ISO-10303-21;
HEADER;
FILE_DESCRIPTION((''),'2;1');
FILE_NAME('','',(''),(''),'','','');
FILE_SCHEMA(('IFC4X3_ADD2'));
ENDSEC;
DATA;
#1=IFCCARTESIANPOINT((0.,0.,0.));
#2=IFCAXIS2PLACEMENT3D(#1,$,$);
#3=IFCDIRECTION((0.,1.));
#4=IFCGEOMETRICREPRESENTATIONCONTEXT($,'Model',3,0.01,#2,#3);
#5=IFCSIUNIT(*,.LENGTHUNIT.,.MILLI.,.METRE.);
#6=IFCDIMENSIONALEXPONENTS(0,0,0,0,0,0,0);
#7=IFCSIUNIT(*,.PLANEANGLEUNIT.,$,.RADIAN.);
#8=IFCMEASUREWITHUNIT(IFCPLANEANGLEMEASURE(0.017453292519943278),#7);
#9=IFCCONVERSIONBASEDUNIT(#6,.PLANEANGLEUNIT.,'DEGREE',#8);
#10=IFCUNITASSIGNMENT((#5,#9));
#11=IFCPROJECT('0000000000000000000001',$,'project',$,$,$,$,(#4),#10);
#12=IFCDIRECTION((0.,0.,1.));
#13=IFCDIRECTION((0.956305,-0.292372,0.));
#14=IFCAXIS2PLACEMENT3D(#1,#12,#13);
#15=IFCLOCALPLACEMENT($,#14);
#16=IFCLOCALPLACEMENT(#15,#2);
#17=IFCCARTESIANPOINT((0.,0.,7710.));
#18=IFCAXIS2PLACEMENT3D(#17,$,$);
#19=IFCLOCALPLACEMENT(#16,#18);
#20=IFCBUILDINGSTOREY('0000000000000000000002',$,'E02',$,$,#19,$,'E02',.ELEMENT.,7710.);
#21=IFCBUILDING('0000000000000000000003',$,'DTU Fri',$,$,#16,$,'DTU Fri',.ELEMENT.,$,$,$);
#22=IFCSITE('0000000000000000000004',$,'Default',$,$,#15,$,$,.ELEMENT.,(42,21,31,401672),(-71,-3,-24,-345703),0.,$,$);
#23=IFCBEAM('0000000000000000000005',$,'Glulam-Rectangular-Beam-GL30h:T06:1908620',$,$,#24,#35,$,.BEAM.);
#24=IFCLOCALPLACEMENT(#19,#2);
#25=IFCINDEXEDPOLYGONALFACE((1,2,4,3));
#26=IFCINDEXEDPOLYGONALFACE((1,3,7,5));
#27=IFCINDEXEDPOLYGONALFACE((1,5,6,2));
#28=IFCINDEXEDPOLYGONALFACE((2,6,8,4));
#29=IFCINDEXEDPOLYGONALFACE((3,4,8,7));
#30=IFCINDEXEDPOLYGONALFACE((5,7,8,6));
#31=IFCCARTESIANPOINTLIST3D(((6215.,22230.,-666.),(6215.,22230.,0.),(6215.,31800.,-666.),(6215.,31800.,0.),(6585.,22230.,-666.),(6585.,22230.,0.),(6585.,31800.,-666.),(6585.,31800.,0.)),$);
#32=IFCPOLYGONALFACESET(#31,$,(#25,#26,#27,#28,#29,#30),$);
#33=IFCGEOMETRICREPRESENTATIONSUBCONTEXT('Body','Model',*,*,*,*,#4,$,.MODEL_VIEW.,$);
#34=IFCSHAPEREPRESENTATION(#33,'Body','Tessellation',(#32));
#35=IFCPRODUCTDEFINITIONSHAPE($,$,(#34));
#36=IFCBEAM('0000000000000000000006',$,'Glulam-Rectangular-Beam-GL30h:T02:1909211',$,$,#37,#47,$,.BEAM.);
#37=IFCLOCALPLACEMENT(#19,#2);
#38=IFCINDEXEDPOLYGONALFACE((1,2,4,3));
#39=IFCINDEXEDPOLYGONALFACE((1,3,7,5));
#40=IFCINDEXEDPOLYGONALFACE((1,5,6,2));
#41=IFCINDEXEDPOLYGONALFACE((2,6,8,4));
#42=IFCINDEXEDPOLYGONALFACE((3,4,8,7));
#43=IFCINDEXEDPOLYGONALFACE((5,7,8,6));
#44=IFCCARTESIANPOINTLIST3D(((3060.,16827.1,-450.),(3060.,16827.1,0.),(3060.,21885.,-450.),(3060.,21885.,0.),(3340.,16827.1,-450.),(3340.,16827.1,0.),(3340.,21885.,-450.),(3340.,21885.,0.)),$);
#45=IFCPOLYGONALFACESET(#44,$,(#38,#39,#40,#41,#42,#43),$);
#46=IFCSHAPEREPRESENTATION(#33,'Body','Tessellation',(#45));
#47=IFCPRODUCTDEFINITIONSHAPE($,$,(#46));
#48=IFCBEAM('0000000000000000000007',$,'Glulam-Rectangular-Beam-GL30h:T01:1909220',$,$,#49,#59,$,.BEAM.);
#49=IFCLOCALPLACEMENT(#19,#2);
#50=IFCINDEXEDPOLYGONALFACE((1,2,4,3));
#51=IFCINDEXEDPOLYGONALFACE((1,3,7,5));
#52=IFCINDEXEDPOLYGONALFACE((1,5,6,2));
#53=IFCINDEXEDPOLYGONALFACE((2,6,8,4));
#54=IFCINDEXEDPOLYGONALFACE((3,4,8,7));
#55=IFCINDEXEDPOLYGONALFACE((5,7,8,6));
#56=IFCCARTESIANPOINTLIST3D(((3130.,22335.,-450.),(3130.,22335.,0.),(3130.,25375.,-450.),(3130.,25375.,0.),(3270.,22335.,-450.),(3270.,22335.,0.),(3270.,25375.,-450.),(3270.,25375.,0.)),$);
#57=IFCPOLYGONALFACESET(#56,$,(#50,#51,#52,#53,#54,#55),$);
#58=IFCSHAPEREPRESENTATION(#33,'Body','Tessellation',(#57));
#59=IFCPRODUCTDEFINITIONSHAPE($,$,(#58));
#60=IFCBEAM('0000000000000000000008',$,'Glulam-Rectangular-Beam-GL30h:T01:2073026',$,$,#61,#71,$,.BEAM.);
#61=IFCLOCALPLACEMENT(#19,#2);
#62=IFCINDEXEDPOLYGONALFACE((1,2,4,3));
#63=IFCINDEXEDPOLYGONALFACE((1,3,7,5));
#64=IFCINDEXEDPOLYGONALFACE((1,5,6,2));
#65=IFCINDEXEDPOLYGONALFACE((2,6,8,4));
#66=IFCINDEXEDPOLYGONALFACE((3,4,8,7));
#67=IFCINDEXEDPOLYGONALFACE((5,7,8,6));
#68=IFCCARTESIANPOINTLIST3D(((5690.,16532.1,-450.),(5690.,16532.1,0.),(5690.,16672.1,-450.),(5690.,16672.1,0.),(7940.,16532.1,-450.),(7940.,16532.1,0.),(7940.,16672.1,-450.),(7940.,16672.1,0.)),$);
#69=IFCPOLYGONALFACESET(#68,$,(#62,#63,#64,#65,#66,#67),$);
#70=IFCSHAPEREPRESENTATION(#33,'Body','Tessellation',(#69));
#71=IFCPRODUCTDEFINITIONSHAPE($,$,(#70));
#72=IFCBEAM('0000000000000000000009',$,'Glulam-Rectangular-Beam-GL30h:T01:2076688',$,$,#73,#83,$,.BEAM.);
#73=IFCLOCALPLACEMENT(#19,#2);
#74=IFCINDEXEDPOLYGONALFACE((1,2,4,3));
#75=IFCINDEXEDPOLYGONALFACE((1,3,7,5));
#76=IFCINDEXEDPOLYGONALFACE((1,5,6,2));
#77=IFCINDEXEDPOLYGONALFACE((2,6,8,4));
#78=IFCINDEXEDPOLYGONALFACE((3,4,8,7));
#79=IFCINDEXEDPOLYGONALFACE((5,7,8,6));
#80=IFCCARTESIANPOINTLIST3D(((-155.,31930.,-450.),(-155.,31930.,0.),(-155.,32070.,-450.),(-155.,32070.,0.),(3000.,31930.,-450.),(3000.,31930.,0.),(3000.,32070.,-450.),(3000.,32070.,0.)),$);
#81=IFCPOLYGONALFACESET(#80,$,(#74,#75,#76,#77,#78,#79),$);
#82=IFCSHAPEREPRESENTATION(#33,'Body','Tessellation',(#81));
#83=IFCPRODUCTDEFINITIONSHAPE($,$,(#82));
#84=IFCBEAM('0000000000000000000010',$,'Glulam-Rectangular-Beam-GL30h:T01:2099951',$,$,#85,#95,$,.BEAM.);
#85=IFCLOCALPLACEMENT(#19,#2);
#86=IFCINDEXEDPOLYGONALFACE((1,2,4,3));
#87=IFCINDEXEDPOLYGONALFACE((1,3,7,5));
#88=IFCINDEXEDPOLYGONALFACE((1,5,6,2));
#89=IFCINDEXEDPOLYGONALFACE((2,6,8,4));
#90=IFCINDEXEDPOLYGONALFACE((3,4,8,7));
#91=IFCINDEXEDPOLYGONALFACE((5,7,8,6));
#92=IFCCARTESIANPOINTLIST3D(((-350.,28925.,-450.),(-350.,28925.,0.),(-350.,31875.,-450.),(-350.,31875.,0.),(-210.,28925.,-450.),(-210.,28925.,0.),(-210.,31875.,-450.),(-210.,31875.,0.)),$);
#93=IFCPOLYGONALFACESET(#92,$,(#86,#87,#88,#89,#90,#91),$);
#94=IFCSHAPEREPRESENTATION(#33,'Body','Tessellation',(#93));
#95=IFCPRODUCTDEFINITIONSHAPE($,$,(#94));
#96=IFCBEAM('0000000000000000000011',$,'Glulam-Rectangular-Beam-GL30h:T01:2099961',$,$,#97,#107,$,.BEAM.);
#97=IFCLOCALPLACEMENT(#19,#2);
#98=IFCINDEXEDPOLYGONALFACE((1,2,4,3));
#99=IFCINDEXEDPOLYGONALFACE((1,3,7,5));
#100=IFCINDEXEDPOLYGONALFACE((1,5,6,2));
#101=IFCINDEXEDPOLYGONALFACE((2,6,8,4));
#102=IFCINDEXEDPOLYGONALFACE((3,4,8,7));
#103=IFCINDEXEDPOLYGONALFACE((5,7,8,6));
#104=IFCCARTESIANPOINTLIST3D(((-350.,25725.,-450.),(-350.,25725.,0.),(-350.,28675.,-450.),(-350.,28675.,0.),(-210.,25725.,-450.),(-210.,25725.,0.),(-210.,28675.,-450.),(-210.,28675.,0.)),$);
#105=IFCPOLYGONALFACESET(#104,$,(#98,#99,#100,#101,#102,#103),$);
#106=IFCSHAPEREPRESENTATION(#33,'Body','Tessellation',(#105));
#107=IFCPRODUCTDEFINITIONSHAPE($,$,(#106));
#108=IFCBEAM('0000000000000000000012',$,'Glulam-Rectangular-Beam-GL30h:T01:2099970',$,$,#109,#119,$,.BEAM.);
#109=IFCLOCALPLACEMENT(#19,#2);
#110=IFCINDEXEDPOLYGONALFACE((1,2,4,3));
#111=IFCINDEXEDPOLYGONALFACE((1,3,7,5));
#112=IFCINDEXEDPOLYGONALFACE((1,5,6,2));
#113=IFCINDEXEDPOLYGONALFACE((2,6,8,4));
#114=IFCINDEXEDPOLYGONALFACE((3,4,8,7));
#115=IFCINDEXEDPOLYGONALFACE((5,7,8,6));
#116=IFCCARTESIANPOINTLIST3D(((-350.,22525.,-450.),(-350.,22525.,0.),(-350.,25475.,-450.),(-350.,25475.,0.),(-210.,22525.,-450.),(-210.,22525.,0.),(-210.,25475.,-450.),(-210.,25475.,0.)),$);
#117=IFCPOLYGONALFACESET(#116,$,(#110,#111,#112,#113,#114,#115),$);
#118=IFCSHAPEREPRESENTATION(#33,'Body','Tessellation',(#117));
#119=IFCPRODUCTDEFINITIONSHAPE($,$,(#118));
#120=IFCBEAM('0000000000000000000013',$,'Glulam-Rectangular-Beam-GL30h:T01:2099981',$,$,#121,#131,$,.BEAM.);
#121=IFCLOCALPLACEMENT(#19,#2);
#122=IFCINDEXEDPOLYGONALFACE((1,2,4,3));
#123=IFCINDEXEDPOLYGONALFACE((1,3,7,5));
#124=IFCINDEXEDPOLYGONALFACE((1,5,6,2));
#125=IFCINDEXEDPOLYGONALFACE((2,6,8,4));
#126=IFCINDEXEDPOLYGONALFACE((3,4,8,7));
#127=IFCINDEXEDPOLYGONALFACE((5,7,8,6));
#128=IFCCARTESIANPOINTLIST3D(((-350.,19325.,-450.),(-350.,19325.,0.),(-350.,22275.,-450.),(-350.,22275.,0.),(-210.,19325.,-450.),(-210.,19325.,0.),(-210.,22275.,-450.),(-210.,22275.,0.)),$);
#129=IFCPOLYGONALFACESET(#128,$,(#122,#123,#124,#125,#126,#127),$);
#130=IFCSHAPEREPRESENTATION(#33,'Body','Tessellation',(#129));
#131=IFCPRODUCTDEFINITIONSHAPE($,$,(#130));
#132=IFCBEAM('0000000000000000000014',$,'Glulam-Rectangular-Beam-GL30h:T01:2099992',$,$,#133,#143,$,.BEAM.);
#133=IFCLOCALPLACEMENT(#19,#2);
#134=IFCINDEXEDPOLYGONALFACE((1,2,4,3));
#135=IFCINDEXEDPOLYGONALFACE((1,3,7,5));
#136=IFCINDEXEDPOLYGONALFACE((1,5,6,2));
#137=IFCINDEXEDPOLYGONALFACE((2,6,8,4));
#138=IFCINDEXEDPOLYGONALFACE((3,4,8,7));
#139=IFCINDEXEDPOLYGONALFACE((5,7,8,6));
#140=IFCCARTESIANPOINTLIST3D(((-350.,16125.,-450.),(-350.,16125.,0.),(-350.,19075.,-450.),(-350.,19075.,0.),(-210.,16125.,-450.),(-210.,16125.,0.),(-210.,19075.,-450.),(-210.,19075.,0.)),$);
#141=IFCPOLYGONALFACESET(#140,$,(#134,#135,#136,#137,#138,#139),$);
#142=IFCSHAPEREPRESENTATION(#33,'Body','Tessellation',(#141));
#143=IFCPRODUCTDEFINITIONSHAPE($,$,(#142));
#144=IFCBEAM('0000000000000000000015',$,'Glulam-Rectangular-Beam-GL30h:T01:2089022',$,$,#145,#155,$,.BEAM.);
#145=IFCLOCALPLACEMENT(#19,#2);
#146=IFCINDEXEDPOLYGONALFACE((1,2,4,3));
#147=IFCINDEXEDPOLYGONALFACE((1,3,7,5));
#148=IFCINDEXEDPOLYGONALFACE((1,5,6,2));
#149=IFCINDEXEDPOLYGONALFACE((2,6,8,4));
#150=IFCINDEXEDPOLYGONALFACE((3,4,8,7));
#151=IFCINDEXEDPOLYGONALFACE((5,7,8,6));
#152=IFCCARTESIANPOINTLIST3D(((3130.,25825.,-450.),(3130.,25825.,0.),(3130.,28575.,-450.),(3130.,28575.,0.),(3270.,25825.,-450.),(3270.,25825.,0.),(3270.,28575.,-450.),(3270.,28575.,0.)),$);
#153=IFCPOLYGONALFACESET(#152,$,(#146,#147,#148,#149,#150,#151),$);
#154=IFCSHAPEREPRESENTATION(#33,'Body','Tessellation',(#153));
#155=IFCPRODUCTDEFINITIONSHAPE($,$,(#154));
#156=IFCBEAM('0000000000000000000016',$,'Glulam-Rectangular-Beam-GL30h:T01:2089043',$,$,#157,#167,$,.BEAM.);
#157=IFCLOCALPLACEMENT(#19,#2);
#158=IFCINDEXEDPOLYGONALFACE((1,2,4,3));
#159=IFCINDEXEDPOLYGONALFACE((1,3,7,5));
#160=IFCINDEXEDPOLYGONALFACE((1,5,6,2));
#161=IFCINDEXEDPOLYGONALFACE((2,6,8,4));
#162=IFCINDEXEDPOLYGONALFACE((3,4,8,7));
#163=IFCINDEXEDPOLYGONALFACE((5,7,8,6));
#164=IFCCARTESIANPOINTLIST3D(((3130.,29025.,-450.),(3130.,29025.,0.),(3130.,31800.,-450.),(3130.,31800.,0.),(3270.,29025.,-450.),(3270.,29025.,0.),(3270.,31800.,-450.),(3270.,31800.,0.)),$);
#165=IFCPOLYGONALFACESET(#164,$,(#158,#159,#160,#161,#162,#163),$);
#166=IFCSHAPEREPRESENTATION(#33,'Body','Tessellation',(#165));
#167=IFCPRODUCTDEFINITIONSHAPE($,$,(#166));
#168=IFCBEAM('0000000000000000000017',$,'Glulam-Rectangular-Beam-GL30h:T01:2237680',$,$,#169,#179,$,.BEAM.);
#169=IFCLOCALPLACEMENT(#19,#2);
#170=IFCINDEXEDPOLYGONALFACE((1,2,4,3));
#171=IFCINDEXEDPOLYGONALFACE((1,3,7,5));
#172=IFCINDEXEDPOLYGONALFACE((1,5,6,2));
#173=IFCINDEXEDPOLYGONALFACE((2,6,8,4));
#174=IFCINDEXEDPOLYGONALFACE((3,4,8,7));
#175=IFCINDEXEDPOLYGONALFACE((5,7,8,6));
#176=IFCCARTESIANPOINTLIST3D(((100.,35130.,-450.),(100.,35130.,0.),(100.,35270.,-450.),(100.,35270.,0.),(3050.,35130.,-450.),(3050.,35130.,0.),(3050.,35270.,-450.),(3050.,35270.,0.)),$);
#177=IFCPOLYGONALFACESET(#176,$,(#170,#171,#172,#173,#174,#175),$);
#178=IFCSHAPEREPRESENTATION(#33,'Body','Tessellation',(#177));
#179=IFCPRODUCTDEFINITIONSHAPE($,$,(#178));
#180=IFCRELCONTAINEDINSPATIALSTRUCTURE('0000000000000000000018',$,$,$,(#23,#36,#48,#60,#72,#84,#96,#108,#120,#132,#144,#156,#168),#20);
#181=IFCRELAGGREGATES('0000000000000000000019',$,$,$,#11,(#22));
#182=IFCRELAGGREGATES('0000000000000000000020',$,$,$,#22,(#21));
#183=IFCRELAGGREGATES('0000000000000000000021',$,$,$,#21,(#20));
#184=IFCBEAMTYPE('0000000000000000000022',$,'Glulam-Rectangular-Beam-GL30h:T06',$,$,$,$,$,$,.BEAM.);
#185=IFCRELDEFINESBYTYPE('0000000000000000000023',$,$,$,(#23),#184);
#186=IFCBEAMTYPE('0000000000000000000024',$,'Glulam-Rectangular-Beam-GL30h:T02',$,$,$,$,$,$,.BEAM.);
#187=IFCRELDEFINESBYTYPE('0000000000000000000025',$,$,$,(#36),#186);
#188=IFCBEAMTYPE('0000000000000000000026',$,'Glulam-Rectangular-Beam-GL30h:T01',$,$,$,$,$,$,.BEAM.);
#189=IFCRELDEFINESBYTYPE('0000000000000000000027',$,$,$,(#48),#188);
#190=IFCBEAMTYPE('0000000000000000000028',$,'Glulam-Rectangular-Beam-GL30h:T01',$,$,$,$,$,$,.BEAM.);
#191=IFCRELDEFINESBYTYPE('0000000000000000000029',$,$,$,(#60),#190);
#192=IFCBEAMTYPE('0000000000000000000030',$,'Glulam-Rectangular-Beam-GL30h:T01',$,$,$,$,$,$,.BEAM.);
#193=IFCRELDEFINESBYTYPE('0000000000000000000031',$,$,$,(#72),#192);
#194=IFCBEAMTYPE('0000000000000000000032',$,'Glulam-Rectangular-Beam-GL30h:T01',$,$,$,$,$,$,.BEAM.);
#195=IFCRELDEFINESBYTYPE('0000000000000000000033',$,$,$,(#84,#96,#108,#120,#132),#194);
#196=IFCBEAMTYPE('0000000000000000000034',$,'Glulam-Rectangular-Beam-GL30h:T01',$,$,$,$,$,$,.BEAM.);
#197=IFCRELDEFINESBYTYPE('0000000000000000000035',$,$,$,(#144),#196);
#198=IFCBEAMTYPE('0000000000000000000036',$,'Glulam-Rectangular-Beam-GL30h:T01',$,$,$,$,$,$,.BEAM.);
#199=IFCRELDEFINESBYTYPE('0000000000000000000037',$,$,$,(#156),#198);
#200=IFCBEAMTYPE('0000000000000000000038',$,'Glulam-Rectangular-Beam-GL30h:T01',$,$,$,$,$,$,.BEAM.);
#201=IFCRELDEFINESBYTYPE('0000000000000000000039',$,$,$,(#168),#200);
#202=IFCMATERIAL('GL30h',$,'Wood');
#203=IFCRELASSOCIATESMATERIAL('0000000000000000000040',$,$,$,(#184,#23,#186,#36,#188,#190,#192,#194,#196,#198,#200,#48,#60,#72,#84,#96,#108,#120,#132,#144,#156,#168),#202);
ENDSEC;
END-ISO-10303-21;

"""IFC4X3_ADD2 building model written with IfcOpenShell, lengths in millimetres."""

from ifc_helpers import new_model, entity, si_unit, converted_unit, direction, frame, origin, origin_2d_with_axis, place, context, subcontext, project, spatial, rectangle, extrude, source, transform, mapped, material, material_profile, profile_set, profile_usage, type_object, type_shapes, element, save


model = new_model("IFC4X3_ADD2")

# Units and contexts
model_context = context("Model", 3, precision=0.01, world=origin(), true_north=direction((0.0, 1.0)))
body_context = subcontext(model_context, "Body", "Model", "MODEL_VIEW")
ifc_project = project(units=[si_unit("LENGTHUNIT", "METRE", prefix="MILLI"), converted_unit("PLANEANGLEUNIT", "DEGREE", entity("IfcPlaneAngleMeasure", 0.017453292519943278), si_unit("PLANEANGLEUNIT", "RADIAN"), dimensions=[0, 0, 0, 0, 0, 0, 0])], contexts=[model_context])

# Site, building, storey
site_placement = place(None, frame((0.0, 0.0, 0.0), z_axis=(0.0, 0.0, 1.0), x_axis=(0.956305, -0.292372, 0.0)))
site = spatial("IfcSite", under=ifc_project, at=site_placement, Name="Default", CompositionType="ELEMENT", RefLatitude=(42, 21, 31, 401672), RefLongitude=(-71, -3, -24, -345703), RefElevation=0.0)
building_placement = place(site_placement, origin())
building = spatial("IfcBuilding", under=site, at=building_placement, Name="DTU Fri", LongName="DTU Fri", CompositionType="ELEMENT")
storey_placement = place(building_placement, frame((0.0, 0.0, 7710.0)))
storey = spatial("IfcBuildingStorey", under=building, at=storey_placement, Name="E02", LongName="E02", CompositionType="ELEMENT", Elevation=7710.0)

# Shared definitions
ifc_material_1 = material(Name="GL30h", Category="Wood")

# Beams
ifc_material_profile_1 = material_profile(ifc_material_1, rectangle(XDim=450.0, YDim=280.0, at=origin_2d_with_axis()), Name="T02")
ifc_profile_set_1 = profile_set([ifc_material_profile_1], Name="T02")
ifc_profile_usage_1 = profile_usage(ifc_profile_set_1, cardinal=8)
ifc_material_profile_2 = material_profile(ifc_material_1, rectangle(XDim=666.0, YDim=370.0, at=origin_2d_with_axis()), Name="T06")
ifc_profile_set_2 = profile_set([ifc_material_profile_2], Name="T06")
ifc_profile_usage_2 = profile_usage(ifc_profile_set_2, cardinal=8)
beam_type_1 = type_object("IfcBeamType", Name="Glulam-Rectangular-Beam-GL30h:T06", PredefinedType="BEAM", material=ifc_profile_set_2)
shared_shape_1 = source(origin(), body_context, "Body", "SweptSolid", [
    extrude(rectangle(XDim=666.0, YDim=370.0, at=origin_2d_with_axis()), frame((-4825.0, 0.0, 0.0), z_axis=(1.0, 0.0, 0.0), x_axis=(0.0, 0.0, -1.0)), (0.0, 0.0, 1.0), 9570.0),
])
type_shapes(beam_type_1, [shared_shape_1])
beam_1_placement = place(storey_placement, frame((6400.0, 27055.0, -333.0), z_axis=(0.0, 0.0, 1.0), x_axis=(0.0, 1.0, 0.0)))
element("IfcBeam", 1, at=beam_1_placement, inside=storey, type_object=beam_type_1, material=ifc_profile_usage_2, Name="Glulam-Rectangular-Beam-GL30h:T06:1908620", PredefinedType="BEAM", context=body_context, shape_type="MappedRepresentation", body=[
    mapped(shared_shape_1, transform((0.0, 0.0, 0.0), scale=1.0)),
])
beam_type_2 = type_object("IfcBeamType", Name="Glulam-Rectangular-Beam-GL30h:T02", PredefinedType="BEAM", material=ifc_profile_set_1)
shared_shape_2 = source(origin(), body_context, "Body", "SweptSolid", [
    extrude(rectangle(XDim=450.0, YDim=280.0, at=origin_2d_with_axis()), frame((-2529.0, 0.0, 0.0), z_axis=(1.0, 0.0, 0.0), x_axis=(0.0, 0.0, -1.0)), (0.0, 0.0, 1.0), 5057.9),
])
type_shapes(beam_type_2, [shared_shape_2])
beam_2_placement = place(storey_placement, frame((3200.0, 19356.0, -225.0), z_axis=(0.0, 0.0, 1.0), x_axis=(0.0, 1.0, 0.0)))
element("IfcBeam", 2, at=beam_2_placement, inside=storey, type_object=beam_type_2, material=ifc_profile_usage_1, Name="Glulam-Rectangular-Beam-GL30h:T02:1909211", PredefinedType="BEAM", context=body_context, shape_type="MappedRepresentation", body=[
    mapped(shared_shape_2, transform((0.0, 0.0, 0.0), scale=1.0)),
])
ifc_material_profile_3 = material_profile(ifc_material_1, rectangle(XDim=450.0, YDim=140.0, at=origin_2d_with_axis()), Name="T01")
ifc_profile_set_3 = profile_set([ifc_material_profile_3], Name="T01")
ifc_profile_usage_3 = profile_usage(ifc_profile_set_3, cardinal=8)
beam_type_3 = type_object("IfcBeamType", Name="Glulam-Rectangular-Beam-GL30h:T01", PredefinedType="BEAM", material=ifc_profile_set_3)
shared_shape_3 = source(origin(), body_context, "Body", "SweptSolid", [
    extrude(rectangle(XDim=450.0, YDim=140.0, at=origin_2d_with_axis()), frame((-1520.0, 0.0, 0.0), z_axis=(1.0, 0.0, 0.0), x_axis=(0.0, 0.0, -1.0)), (0.0, 0.0, 1.0), 3040.0),
])
type_shapes(beam_type_3, [shared_shape_3])
beam_3_placement = place(storey_placement, frame((3200.0, 23855.0, -225.0), z_axis=(0.0, 0.0, 1.0), x_axis=(0.0, 1.0, 0.0)))
element("IfcBeam", 3, at=beam_3_placement, inside=storey, type_object=beam_type_3, material=ifc_profile_usage_3, Name="Glulam-Rectangular-Beam-GL30h:T01:1909220", PredefinedType="BEAM", context=body_context, shape_type="MappedRepresentation", body=[
    mapped(shared_shape_3, transform((0.0, 0.0, 0.0), scale=1.0)),
])
beam_type_4 = type_object("IfcBeamType", Name="Glulam-Rectangular-Beam-GL30h:T01", PredefinedType="BEAM", material=ifc_profile_set_3)
shared_shape_4 = source(origin(), body_context, "Body", "SweptSolid", [
    extrude(rectangle(XDim=450.0, YDim=140.0, at=origin_2d_with_axis()), frame((-1125.0, 0.0, 0.0), z_axis=(1.0, 0.0, 0.0), x_axis=(0.0, 0.0, -1.0)), (0.0, 0.0, 1.0), 2250.0),
])
type_shapes(beam_type_4, [shared_shape_4])
beam_4_placement = place(storey_placement, frame((6815.0, 16602.1, -225.0), z_axis=(0.0, 0.0, 1.0), x_axis=(-1.0, 0.0, 0.0)))
element("IfcBeam", 4, at=beam_4_placement, inside=storey, type_object=beam_type_4, material=ifc_profile_usage_3, Name="Glulam-Rectangular-Beam-GL30h:T01:2073026", PredefinedType="BEAM", context=body_context, shape_type="MappedRepresentation", body=[
    mapped(shared_shape_4, transform((0.0, 0.0, 0.0), scale=1.0)),
])
beam_type_5 = type_object("IfcBeamType", Name="Glulam-Rectangular-Beam-GL30h:T01", PredefinedType="BEAM", material=ifc_profile_set_3)
shared_shape_5 = source(origin(), body_context, "Body", "SweptSolid", [
    extrude(rectangle(XDim=450.0, YDim=140.0, at=origin_2d_with_axis()), frame((-1590.0, 0.0, 0.0), z_axis=(1.0, 0.0, 0.0), x_axis=(0.0, 0.0, -1.0)), (0.0, 0.0, 1.0), 3155.0),
])
type_shapes(beam_type_5, [shared_shape_5])
beam_5_placement = place(storey_placement, frame((1435.0, 32000.0, -225.0)))
element("IfcBeam", 5, at=beam_5_placement, inside=storey, type_object=beam_type_5, material=ifc_profile_usage_3, Name="Glulam-Rectangular-Beam-GL30h:T01:2076688", PredefinedType="BEAM", context=body_context, shape_type="MappedRepresentation", body=[
    mapped(shared_shape_5, transform((0.0, 0.0, 0.0), scale=1.0)),
])
beam_type_6 = type_object("IfcBeamType", Name="Glulam-Rectangular-Beam-GL30h:T01", PredefinedType="BEAM", material=ifc_profile_set_3)
shared_shape_6 = source(origin(), body_context, "Body", "SweptSolid", [
    extrude(rectangle(XDim=450.0, YDim=140.0, at=origin_2d_with_axis()), frame((-1475.0, 0.0, 0.0), z_axis=(1.0, 0.0, 0.0), x_axis=(0.0, 0.0, -1.0)), (0.0, 0.0, 1.0), 2950.0),
])
type_shapes(beam_type_6, [shared_shape_6])
for number, where, z_axis, x_axis, name in (
    (6, (-280.0, 30400.0, -225.0), (0.0, 0.0, 1.0), (0.0, 1.0, 0.0), "Glulam-Rectangular-Beam-GL30h:T01:2099951"),
    (7, (-280.0, 27200.0, -225.0), (0.0, 0.0, 1.0), (0.0, 1.0, 0.0), "Glulam-Rectangular-Beam-GL30h:T01:2099961"),
    (8, (-280.0, 24000.0, -225.0), (0.0, 0.0, 1.0), (0.0, 1.0, 0.0), "Glulam-Rectangular-Beam-GL30h:T01:2099970"),
    (9, (-280.0, 20800.0, -225.0), (0.0, 0.0, 1.0), (0.0, 1.0, 0.0), "Glulam-Rectangular-Beam-GL30h:T01:2099981"),
    (10, (-280.0, 17600.0, -225.0), (0.0, 0.0, 1.0), (0.0, 1.0, 0.0), "Glulam-Rectangular-Beam-GL30h:T01:2099992"),
):
    element("IfcBeam", number, at=place(storey_placement, frame(where, z_axis=z_axis, x_axis=x_axis)), inside=storey, type_object=beam_type_6, material=ifc_profile_usage_3, Name=name, PredefinedType="BEAM", context=body_context, shape_type="MappedRepresentation", body=[
        mapped(shared_shape_6, transform((0.0, 0.0, 0.0), scale=1.0)),
    ])
beam_type_7 = type_object("IfcBeamType", Name="Glulam-Rectangular-Beam-GL30h:T01", PredefinedType="BEAM", material=ifc_profile_set_3)
shared_shape_7 = source(origin(), body_context, "Body", "SweptSolid", [
    extrude(rectangle(XDim=450.0, YDim=140.0, at=origin_2d_with_axis()), frame((-1375.0, 0.0, 0.0), z_axis=(1.0, 0.0, 0.0), x_axis=(0.0, 0.0, -1.0)), (0.0, 0.0, 1.0), 2750.0),
])
type_shapes(beam_type_7, [shared_shape_7])
beam_6_placement = place(storey_placement, frame((3200.0, 27200.0, -225.0), z_axis=(0.0, 0.0, 1.0), x_axis=(0.0, 1.0, 0.0)))
element("IfcBeam", 11, at=beam_6_placement, inside=storey, type_object=beam_type_7, material=ifc_profile_usage_3, Name="Glulam-Rectangular-Beam-GL30h:T01:2089022", PredefinedType="BEAM", context=body_context, shape_type="MappedRepresentation", body=[
    mapped(shared_shape_7, transform((0.0, 0.0, 0.0), scale=1.0)),
])
beam_type_8 = type_object("IfcBeamType", Name="Glulam-Rectangular-Beam-GL30h:T01", PredefinedType="BEAM", material=ifc_profile_set_3)
shared_shape_8 = source(origin(), body_context, "Body", "SweptSolid", [
    extrude(rectangle(XDim=450.0, YDim=140.0, at=origin_2d_with_axis()), frame((-1375.0, 0.0, 0.0), z_axis=(1.0, 0.0, 0.0), x_axis=(0.0, 0.0, -1.0)), (0.0, 0.0, 1.0), 2775.0),
])
type_shapes(beam_type_8, [shared_shape_8])
beam_7_placement = place(storey_placement, frame((3200.0, 30400.0, -225.0), z_axis=(0.0, 0.0, 1.0), x_axis=(0.0, 1.0, 0.0)))
element("IfcBeam", 12, at=beam_7_placement, inside=storey, type_object=beam_type_8, material=ifc_profile_usage_3, Name="Glulam-Rectangular-Beam-GL30h:T01:2089043", PredefinedType="BEAM", context=body_context, shape_type="MappedRepresentation", body=[
    mapped(shared_shape_8, transform((0.0, 0.0, 0.0), scale=1.0)),
])
beam_type_9 = type_object("IfcBeamType", Name="Glulam-Rectangular-Beam-GL30h:T01", PredefinedType="BEAM", material=ifc_profile_set_3)
shared_shape_9 = source(origin(), body_context, "Body", "SweptSolid", [
    extrude(rectangle(XDim=450.0, YDim=140.0, at=origin_2d_with_axis()), frame((-1500.0, 0.0, 0.0), z_axis=(1.0, 0.0, 0.0), x_axis=(0.0, 0.0, -1.0)), (0.0, 0.0, 1.0), 2950.0),
])
type_shapes(beam_type_9, [shared_shape_9])
beam_8_placement = place(storey_placement, frame((1600.0, 35200.0, -225.0)))
element("IfcBeam", 13, at=beam_8_placement, inside=storey, type_object=beam_type_9, material=ifc_profile_usage_3, Name="Glulam-Rectangular-Beam-GL30h:T01:2237680", PredefinedType="BEAM", context=body_context, shape_type="MappedRepresentation", body=[
    mapped(shared_shape_9, transform((0.0, 0.0, 0.0), scale=1.0)),
])

save(model, "model.ifc")
